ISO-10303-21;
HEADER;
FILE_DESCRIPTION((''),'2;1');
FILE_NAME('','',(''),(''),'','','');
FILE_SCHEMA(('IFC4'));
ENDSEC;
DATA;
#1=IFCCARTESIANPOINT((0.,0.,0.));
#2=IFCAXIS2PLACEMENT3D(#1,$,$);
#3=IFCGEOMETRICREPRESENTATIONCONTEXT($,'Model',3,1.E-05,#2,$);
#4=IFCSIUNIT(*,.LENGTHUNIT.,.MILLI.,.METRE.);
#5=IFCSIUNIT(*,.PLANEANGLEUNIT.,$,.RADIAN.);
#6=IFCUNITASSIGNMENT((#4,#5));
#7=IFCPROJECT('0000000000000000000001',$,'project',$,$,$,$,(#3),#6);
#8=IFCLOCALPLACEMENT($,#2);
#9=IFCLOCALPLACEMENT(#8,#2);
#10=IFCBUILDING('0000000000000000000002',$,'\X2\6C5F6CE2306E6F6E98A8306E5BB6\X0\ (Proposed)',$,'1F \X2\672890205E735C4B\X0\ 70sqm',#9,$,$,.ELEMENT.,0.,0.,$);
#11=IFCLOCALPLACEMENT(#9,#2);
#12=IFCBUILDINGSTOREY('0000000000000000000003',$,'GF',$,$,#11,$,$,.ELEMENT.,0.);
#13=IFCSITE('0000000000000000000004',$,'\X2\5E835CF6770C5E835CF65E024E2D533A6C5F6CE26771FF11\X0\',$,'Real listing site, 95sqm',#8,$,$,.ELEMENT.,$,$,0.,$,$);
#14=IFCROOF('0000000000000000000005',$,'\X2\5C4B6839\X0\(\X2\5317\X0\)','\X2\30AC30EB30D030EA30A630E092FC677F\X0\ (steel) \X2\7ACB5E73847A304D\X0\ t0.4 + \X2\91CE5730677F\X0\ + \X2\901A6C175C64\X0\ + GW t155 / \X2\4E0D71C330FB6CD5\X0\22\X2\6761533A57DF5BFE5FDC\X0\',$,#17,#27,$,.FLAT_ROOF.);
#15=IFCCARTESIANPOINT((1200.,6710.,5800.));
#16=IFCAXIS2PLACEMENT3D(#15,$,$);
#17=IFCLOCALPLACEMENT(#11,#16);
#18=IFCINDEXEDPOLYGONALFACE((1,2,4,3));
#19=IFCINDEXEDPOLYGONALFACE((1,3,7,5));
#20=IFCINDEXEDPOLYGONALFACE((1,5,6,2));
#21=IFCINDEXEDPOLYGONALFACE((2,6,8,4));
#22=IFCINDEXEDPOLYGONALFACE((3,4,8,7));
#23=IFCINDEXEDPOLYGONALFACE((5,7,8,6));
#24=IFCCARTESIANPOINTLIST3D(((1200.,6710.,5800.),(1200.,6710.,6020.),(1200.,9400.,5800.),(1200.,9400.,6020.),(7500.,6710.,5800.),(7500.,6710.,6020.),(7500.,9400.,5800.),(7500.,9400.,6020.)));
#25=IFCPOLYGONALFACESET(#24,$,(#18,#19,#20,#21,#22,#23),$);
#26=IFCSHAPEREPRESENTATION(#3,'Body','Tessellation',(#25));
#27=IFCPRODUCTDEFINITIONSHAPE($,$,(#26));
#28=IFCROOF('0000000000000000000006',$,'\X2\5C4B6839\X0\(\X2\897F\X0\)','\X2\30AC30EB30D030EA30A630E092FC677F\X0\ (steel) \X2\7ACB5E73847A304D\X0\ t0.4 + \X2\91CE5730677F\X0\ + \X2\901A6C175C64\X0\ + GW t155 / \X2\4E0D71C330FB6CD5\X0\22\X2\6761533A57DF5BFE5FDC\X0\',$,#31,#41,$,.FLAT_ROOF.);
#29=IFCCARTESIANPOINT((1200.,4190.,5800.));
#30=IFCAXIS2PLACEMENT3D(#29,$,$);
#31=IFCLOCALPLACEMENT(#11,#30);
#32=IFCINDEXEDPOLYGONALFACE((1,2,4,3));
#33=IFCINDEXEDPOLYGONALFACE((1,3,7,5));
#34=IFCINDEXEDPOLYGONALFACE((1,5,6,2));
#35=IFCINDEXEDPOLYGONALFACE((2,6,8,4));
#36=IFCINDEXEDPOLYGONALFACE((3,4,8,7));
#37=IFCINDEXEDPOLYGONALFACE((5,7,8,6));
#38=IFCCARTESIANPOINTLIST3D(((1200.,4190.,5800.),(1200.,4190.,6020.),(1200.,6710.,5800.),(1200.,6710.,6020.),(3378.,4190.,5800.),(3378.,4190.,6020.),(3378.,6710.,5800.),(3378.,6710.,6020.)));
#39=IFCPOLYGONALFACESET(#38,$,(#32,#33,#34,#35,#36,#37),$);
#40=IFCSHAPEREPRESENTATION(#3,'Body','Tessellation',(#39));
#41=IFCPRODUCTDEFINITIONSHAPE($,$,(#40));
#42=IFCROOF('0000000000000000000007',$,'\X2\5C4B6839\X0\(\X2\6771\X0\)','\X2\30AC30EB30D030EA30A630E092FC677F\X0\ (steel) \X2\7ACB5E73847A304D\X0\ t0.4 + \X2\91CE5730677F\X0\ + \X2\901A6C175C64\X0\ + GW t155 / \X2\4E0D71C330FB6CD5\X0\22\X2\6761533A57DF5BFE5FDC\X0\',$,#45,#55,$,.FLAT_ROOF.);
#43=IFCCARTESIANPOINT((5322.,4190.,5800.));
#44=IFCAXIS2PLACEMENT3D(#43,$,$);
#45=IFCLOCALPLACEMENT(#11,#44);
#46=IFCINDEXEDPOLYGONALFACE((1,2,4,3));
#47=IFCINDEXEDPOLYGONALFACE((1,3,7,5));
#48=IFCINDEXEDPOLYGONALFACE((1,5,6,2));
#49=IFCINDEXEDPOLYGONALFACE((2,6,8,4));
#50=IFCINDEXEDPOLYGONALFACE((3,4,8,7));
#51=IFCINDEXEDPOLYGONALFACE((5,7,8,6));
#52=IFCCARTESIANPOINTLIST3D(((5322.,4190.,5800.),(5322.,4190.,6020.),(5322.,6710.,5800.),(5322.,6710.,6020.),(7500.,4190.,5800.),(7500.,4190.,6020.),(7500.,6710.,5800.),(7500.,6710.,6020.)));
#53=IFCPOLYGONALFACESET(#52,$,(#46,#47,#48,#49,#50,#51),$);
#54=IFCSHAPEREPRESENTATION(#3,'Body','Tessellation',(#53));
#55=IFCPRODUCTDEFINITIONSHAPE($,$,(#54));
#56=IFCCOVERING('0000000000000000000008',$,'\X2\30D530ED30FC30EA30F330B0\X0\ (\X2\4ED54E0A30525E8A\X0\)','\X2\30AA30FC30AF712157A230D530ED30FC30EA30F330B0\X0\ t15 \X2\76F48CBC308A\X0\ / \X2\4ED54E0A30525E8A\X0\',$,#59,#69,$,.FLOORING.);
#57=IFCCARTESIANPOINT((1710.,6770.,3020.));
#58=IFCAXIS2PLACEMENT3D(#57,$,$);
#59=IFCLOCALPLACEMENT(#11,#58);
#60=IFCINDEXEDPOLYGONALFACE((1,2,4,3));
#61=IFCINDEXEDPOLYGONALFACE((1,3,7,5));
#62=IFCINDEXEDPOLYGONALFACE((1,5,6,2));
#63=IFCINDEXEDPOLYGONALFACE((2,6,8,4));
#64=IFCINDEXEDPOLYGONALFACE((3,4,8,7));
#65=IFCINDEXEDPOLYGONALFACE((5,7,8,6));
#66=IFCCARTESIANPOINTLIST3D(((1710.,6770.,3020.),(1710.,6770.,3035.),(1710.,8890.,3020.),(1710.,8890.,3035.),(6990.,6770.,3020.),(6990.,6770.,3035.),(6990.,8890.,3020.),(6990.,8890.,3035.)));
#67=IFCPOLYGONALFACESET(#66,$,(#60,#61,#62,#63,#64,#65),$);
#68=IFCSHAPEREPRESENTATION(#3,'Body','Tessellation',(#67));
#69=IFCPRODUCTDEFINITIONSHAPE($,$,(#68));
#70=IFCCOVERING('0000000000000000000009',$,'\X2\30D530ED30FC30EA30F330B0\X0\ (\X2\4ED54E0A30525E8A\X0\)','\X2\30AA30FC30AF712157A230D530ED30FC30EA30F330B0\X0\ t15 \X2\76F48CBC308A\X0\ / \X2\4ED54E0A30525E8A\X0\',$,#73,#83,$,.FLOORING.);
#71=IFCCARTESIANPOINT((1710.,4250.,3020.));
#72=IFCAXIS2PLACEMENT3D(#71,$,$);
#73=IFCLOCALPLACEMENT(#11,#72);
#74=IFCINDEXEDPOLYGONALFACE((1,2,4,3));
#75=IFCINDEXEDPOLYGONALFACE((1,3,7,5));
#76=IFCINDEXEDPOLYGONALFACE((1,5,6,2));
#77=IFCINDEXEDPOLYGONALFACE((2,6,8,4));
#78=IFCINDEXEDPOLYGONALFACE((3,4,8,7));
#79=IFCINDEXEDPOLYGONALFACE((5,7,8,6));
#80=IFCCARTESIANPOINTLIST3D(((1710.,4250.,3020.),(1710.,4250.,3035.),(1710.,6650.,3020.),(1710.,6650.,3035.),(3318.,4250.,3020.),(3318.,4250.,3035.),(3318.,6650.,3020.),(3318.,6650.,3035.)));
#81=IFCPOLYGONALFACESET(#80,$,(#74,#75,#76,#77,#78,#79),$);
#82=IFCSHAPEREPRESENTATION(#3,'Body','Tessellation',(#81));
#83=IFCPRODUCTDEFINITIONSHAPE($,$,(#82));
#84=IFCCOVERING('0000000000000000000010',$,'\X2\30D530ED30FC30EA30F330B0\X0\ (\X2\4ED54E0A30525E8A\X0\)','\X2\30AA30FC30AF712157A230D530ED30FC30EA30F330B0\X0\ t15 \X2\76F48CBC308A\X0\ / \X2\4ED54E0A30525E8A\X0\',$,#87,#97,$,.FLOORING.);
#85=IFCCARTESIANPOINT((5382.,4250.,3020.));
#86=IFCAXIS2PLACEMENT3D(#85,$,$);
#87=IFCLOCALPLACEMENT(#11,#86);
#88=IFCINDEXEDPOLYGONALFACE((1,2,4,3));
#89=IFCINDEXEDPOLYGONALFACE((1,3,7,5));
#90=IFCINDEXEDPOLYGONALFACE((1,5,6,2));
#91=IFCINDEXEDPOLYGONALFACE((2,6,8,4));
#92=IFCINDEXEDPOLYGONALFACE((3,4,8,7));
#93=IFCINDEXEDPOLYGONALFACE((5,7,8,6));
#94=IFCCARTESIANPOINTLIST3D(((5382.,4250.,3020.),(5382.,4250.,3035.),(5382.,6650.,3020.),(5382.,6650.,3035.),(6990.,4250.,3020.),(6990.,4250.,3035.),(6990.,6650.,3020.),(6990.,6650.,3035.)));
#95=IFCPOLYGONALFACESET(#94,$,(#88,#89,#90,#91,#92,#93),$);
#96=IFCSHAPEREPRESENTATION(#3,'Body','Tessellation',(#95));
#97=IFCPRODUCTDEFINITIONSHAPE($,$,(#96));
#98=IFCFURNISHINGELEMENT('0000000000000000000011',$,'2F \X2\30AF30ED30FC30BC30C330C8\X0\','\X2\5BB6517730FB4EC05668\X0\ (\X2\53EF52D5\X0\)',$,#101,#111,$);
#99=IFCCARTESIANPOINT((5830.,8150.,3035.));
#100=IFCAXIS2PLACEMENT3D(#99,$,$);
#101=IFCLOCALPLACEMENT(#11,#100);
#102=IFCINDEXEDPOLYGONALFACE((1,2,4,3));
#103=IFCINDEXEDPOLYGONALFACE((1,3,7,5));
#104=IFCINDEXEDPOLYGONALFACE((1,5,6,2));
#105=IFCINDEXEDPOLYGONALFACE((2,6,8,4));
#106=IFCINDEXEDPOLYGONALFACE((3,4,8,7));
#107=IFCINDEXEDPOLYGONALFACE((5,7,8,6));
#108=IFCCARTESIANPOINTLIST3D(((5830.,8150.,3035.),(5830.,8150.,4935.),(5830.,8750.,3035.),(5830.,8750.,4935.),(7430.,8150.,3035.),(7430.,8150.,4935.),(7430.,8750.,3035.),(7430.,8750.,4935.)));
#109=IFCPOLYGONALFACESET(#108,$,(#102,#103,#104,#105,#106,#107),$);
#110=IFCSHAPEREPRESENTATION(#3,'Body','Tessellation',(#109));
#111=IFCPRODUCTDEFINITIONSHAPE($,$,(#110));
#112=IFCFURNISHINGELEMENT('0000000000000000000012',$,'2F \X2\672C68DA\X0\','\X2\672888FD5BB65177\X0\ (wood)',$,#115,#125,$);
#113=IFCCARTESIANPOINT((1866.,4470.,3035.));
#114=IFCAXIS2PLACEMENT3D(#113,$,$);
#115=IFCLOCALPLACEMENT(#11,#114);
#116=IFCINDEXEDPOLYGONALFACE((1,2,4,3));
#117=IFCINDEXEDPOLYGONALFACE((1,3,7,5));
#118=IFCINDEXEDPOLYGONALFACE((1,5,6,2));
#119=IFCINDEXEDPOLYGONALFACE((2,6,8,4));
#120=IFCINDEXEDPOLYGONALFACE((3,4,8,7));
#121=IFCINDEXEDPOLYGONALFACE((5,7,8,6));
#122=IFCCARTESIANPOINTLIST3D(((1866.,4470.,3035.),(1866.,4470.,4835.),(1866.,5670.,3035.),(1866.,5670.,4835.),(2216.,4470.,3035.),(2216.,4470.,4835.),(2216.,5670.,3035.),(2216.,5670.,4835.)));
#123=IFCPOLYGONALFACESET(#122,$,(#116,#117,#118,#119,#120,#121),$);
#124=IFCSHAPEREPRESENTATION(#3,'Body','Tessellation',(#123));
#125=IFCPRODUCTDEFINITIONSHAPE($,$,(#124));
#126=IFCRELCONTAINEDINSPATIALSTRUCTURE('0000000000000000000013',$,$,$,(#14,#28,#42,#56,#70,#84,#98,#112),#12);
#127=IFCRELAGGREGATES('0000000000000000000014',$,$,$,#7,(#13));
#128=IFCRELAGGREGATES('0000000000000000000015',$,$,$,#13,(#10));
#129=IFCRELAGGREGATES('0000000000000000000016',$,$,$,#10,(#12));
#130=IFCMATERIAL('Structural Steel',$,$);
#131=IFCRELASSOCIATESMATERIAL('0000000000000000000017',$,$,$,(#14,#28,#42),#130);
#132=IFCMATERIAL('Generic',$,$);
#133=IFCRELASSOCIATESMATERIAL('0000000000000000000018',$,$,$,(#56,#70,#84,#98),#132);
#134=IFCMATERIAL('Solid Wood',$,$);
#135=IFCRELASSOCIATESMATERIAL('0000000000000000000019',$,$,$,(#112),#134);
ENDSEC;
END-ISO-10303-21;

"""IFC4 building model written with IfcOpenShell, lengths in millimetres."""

from ifc_helpers import new_model, si_unit, frame, frame_2d, origin, place, context, project, spatial, rectangle, extrude, material, element, save


model = new_model("IFC4")

# Units and contexts
model_context = context("Model", 3, precision=1e-05, world=origin())
ifc_project = project(units=[si_unit("LENGTHUNIT", "METRE", prefix="MILLI"), si_unit("PLANEANGLEUNIT", "RADIAN")], contexts=[model_context])

# Site, building, storey
site_placement = place(None, origin())
site = spatial("IfcSite", under=ifc_project, at=site_placement, Name="広島県広島市中区江波東１", ObjectType="Real listing site, 95sqm", CompositionType="ELEMENT", RefElevation=0.0)
building_placement = place(site_placement, origin())
building = spatial("IfcBuilding", under=site, at=building_placement, Name="江波の潮風の家 (Proposed)", ObjectType="1F 木造平屋 70sqm", CompositionType="ELEMENT", ElevationOfRefHeight=0.0, ElevationOfTerrain=0.0)
storey_placement = place(building_placement, origin())
storey = spatial("IfcBuildingStorey", under=building, at=storey_placement, Name="GF", CompositionType="ELEMENT", Elevation=0.0)

# Shared definitions
ifc_material_1 = material(Name="Solid Wood")

# Shared definitions
ifc_material_2 = material(Name="Generic")

# Roofs
ifc_material_3 = material(Name="Structural Steel")
for number, where, name in (
    (1, (1200.0, 6710.0, 5800.0), "屋根(北)"),
):
    element("IfcRoof", number, at=place(storey_placement, frame(where)), inside=storey, material=ifc_material_3, Name=name, Description="ガルバリウム鋼板 (steel) 立平葺き t0.4 + 野地板 + 通気層 + GW t155 / 不燃・法22条区域対応", PredefinedType="FLAT_ROOF", context=model_context, shape_type="SweptSolid", body=[
        extrude(rectangle(XDim=6300.0, YDim=2690.0, at=frame_2d((3150.0, 1345.0))), frame((1200.0, 6710.0, 5800.0)), (0.0, 0.0, 1.0), 220.0),
    ])
roof_1_placement = place(storey_placement, frame((1200.0, 4190.0, 5800.0)))
element("IfcRoof", 2, at=roof_1_placement, inside=storey, material=ifc_material_3, Name="屋根(西)", Description="ガルバリウム鋼板 (steel) 立平葺き t0.4 + 野地板 + 通気層 + GW t155 / 不燃・法22条区域対応", PredefinedType="FLAT_ROOF", context=model_context, shape_type="SweptSolid", body=[
    extrude(rectangle(XDim=2178.0, YDim=2520.0, at=frame_2d((1089.0, 1260.0))), frame((1200.0, 4190.0, 5800.0)), (0.0, 0.0, 1.0), 220.0),
])
roof_2_placement = place(storey_placement, frame((5322.0, 4190.0, 5800.0)))
element("IfcRoof", 3, at=roof_2_placement, inside=storey, material=ifc_material_3, Name="屋根(東)", Description="ガルバリウム鋼板 (steel) 立平葺き t0.4 + 野地板 + 通気層 + GW t155 / 不燃・法22条区域対応", PredefinedType="FLAT_ROOF", context=model_context, shape_type="SweptSolid", body=[
    extrude(rectangle(XDim=2178.0, YDim=2520.0, at=frame_2d((1089.0, 1260.0))), frame((5322.0, 4190.0, 5800.0)), (0.0, 0.0, 1.0), 220.0),
])

# Coverings
covering_1_placement = place(storey_placement, frame((1710.0, 6770.0, 3020.0)))
element("IfcCovering", 4, at=covering_1_placement, inside=storey, material=ifc_material_2, Name="フローリング (仕上げ床)", Description="オーク無垢フローリング t15 直貼り / 仕上げ床", PredefinedType="FLOORING", context=model_context, shape_type="SweptSolid", body=[
    extrude(rectangle(XDim=5280.0, YDim=2120.0, at=frame_2d((2640.0, 1060.0))), frame((1710.0, 6770.0, 3020.0)), (0.0, 0.0, 1.0), 15.0),
])
covering_2_placement = place(storey_placement, frame((1710.0, 4250.0, 3020.0)))
element("IfcCovering", 5, at=covering_2_placement, inside=storey, material=ifc_material_2, Name="フローリング (仕上げ床)", Description="オーク無垢フローリング t15 直貼り / 仕上げ床", PredefinedType="FLOORING", context=model_context, shape_type="SweptSolid", body=[
    extrude(rectangle(XDim=1608.0, YDim=2400.0, at=frame_2d((804.0, 1200.0))), frame((1710.0, 4250.0, 3020.0)), (0.0, 0.0, 1.0), 15.0),
])
covering_3_placement = place(storey_placement, frame((5382.0, 4250.0, 3020.0)))
element("IfcCovering", 6, at=covering_3_placement, inside=storey, material=ifc_material_2, Name="フローリング (仕上げ床)", Description="オーク無垢フローリング t15 直貼り / 仕上げ床", PredefinedType="FLOORING", context=model_context, shape_type="SweptSolid", body=[
    extrude(rectangle(XDim=1608.0, YDim=2400.0, at=frame_2d((804.0, 1200.0))), frame((5382.0, 4250.0, 3020.0)), (0.0, 0.0, 1.0), 15.0),
])

# Furnishing elements
furnishing_1_placement = place(storey_placement, frame((5830.0, 8150.0, 3035.0)))
element("IfcFurnishingElement", 7, at=furnishing_1_placement, inside=storey, material=ifc_material_2, Name="2F クローゼット", Description="家具・什器 (可動)", context=model_context, shape_type="SweptSolid", body=[
    extrude(rectangle(XDim=1600.0, YDim=600.0, at=frame_2d((800.0, 300.0))), frame((5830.0, 8150.0, 3035.0)), (0.0, 0.0, 1.0), 1900.0),
])
furnishing_2_placement = place(storey_placement, frame((1866.0, 4470.0, 3035.0)))
element("IfcFurnishingElement", 8, at=furnishing_2_placement, inside=storey, material=ifc_material_1, Name="2F 本棚", Description="木製家具 (wood)", context=model_context, shape_type="SweptSolid", body=[
    extrude(rectangle(XDim=350.0, YDim=1200.0, at=frame_2d((175.0, 600.0))), frame((1866.0, 4470.0, 3035.0)), (0.0, 0.0, 1.0), 1800.0),
])

save(model, "model.ifc")
